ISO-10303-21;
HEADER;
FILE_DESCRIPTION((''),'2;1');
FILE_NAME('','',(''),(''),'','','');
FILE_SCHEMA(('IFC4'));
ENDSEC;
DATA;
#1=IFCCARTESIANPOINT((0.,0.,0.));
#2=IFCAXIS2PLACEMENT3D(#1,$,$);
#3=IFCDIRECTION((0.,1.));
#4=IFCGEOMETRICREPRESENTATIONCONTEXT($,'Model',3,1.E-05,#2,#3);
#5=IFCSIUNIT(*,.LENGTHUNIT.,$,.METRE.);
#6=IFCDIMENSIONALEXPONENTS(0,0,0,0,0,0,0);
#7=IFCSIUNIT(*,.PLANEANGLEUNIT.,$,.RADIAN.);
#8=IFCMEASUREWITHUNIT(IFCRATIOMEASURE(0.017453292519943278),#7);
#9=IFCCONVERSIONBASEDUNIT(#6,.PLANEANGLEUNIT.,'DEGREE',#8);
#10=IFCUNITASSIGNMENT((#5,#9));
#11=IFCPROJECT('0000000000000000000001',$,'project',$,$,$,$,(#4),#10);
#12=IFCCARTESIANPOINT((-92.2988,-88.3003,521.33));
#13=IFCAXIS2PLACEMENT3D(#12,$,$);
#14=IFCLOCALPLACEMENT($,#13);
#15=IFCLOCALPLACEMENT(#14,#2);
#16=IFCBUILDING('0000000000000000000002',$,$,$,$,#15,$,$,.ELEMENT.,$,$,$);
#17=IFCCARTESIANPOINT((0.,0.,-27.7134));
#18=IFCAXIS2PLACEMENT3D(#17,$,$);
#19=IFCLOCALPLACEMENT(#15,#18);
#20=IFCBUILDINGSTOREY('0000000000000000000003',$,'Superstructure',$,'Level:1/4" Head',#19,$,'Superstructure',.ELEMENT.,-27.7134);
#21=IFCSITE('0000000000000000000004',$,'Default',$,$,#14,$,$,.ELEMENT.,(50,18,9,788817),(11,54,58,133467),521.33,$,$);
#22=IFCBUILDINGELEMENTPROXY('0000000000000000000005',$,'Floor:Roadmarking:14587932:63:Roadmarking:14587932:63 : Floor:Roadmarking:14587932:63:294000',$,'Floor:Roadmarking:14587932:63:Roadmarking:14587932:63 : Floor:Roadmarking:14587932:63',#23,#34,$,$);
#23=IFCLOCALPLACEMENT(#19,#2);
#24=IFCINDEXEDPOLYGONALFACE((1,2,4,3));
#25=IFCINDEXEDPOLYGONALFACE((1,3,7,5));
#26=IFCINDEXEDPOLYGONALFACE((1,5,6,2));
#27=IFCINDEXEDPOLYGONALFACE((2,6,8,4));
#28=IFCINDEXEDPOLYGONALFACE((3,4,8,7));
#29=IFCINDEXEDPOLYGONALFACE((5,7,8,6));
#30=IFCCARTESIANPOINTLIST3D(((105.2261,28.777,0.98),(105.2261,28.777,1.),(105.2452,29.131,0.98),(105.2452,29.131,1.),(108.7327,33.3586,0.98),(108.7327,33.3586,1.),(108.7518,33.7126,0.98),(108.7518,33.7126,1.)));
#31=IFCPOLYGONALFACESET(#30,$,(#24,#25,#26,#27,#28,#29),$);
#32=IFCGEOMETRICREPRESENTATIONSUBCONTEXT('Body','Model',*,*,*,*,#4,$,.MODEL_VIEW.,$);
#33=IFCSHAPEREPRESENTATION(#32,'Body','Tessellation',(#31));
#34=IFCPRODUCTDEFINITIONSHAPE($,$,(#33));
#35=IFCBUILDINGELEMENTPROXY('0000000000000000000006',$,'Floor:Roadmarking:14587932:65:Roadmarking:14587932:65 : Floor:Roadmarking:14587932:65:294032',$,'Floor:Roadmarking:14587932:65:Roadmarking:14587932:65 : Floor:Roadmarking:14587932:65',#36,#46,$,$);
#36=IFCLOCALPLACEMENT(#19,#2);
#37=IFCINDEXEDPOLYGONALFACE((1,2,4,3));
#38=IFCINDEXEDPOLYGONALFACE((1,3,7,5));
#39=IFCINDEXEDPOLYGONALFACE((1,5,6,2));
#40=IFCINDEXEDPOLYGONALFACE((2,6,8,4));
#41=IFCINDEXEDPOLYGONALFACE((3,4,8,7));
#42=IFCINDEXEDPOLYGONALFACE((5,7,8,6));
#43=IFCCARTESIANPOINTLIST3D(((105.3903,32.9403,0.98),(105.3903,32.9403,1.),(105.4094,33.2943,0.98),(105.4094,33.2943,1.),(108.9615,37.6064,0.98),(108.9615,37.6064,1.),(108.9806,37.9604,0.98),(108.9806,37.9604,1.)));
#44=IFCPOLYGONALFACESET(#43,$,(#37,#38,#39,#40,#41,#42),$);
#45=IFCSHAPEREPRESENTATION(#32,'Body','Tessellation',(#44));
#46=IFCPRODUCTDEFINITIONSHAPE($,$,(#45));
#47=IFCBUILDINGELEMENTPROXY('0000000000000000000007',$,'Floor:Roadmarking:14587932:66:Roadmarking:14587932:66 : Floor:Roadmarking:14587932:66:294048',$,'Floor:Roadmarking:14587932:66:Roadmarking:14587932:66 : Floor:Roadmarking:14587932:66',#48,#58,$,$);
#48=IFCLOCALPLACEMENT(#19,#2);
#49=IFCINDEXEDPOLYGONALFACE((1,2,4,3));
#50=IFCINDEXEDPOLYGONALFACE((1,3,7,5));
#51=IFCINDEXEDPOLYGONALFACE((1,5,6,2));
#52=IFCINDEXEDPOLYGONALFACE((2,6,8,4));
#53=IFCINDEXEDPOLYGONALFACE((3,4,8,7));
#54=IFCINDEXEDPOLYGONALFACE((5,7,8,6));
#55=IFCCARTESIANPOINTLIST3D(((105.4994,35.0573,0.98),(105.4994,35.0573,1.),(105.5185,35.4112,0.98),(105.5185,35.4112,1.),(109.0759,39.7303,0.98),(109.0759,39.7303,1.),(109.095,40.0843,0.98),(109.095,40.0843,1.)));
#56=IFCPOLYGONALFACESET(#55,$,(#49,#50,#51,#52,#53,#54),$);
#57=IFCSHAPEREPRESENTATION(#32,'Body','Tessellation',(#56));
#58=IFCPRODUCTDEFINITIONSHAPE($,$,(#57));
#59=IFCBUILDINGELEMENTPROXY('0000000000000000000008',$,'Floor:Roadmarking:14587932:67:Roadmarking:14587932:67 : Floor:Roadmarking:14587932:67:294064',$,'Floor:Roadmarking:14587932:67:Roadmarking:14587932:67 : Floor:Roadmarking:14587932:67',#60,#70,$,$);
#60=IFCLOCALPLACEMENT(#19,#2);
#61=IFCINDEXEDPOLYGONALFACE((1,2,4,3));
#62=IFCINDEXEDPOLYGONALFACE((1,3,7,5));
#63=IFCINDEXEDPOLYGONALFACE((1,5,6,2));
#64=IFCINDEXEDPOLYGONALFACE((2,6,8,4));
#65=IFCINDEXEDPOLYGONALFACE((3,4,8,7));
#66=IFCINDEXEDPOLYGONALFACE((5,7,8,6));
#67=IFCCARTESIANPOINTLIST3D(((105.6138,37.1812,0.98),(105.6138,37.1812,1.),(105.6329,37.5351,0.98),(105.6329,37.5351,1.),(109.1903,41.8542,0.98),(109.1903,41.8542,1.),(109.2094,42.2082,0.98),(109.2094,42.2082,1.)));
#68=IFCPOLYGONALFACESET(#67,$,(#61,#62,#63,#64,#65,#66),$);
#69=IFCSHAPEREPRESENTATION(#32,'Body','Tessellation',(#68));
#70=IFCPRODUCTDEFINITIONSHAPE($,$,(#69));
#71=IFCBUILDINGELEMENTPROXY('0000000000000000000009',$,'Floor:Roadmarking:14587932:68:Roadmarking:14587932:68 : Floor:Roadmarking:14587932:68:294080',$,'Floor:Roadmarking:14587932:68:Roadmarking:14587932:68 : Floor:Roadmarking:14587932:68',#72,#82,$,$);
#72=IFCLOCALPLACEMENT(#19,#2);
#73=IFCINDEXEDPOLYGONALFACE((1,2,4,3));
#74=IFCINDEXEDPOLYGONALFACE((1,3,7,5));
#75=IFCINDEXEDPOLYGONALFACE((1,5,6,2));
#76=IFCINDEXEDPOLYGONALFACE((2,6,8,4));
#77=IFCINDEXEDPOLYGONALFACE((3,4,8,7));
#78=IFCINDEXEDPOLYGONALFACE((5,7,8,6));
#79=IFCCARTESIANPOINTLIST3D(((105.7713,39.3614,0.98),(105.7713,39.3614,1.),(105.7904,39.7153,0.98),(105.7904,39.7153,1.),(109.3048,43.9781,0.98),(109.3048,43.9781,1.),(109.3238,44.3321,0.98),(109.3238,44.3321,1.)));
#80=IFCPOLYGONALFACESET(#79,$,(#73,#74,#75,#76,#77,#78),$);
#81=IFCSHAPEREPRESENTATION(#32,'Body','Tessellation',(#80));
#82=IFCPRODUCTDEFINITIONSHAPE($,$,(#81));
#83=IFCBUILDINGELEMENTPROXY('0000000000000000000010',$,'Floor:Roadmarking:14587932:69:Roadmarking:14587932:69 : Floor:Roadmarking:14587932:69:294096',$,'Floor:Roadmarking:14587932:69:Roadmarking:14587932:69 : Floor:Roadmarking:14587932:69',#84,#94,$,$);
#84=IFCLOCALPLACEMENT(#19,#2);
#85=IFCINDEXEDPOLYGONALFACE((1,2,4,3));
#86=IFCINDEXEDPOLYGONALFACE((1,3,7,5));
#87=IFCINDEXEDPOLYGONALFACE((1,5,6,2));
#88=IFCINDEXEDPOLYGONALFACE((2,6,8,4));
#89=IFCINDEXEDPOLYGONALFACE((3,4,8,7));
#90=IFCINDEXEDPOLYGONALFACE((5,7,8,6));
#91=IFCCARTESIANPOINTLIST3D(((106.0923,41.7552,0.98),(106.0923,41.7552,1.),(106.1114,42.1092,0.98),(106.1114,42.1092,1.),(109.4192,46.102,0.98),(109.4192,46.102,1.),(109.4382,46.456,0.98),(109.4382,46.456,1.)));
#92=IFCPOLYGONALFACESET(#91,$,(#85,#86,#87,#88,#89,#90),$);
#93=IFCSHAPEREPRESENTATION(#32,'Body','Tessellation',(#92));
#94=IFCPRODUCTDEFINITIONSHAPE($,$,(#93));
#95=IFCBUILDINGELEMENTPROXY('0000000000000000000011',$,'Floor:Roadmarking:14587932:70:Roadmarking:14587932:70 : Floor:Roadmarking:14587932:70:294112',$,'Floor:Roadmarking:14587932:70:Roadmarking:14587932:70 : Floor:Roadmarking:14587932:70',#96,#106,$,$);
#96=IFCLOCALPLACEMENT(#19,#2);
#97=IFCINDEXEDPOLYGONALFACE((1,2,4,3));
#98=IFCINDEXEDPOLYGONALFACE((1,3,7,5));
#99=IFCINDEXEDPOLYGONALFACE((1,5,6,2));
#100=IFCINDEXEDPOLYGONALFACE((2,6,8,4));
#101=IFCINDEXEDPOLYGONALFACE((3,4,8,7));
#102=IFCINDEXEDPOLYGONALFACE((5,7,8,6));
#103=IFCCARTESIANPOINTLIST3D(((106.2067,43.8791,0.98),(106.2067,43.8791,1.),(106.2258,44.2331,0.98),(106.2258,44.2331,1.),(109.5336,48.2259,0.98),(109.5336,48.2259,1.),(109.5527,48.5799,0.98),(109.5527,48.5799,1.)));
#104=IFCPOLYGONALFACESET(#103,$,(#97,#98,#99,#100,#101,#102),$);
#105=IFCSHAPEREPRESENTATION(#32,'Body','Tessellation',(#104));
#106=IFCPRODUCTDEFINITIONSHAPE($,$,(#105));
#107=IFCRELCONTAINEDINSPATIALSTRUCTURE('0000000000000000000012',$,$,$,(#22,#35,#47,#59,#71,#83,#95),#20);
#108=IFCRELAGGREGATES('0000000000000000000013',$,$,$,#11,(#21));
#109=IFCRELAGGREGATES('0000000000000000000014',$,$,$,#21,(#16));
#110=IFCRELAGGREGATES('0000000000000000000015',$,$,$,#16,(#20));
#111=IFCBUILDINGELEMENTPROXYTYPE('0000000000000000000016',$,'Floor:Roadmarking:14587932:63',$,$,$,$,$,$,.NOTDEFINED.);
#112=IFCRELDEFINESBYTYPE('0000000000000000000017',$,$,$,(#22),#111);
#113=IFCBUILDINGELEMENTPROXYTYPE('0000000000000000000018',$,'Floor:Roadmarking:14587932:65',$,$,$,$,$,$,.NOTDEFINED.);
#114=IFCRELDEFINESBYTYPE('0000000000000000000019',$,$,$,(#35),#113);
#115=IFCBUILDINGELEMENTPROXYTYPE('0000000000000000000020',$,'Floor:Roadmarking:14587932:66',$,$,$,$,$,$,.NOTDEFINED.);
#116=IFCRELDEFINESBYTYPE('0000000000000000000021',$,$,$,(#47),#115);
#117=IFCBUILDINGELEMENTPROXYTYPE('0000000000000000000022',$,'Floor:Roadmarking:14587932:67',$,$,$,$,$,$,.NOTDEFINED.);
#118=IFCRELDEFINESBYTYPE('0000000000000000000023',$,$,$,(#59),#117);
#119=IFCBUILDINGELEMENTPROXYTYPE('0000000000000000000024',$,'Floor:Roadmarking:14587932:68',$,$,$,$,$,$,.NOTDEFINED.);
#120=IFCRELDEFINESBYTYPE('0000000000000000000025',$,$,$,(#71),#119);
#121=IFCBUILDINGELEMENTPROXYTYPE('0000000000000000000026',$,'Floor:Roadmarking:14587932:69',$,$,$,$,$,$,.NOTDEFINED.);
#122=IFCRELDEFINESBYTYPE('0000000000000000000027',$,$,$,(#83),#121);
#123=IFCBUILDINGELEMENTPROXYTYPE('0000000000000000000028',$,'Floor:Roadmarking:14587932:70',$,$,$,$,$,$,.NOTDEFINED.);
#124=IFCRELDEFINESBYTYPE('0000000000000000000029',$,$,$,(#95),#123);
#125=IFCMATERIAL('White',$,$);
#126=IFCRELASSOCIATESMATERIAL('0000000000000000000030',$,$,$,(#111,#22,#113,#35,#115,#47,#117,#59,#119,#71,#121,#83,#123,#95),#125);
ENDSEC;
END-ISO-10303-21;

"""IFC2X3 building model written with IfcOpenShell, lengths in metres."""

from ifc_helpers import new_model, entity, si_unit, converted_unit, direction, frame, origin, place, context, subcontext, project, spatial, polyline, outline, extrude, source, transform, mapped, material, type_object, type_shapes, element, save


model = new_model("IFC2X3")

# Units and contexts
model_context = context("Model", 3, precision=1e-05, world=origin(), true_north=direction((0.0, 1.0)))
body_context = subcontext(model_context, "Body", "Model", "MODEL_VIEW")
ifc_project = project(units=[si_unit("LENGTHUNIT", "METRE"), converted_unit("PLANEANGLEUNIT", "DEGREE", entity("IfcRatioMeasure", 0.017453292519943278), si_unit("PLANEANGLEUNIT", "RADIAN"), dimensions=[0, 0, 0, 0, 0, 0, 0])], contexts=[model_context])

# Site, building, storey
site_placement = place(None, frame((-92.2988, -88.3003, 521.33)))
site = spatial("IfcSite", under=ifc_project, at=site_placement, Name="Default", CompositionType="ELEMENT", RefLatitude=(50, 18, 9, 788817), RefLongitude=(11, 54, 58, 133467), RefElevation=521.33)
building_placement = place(site_placement, origin())
building = spatial("IfcBuilding", under=site, at=building_placement, CompositionType="ELEMENT")
storey_placement = place(building_placement, frame((0.0, 0.0, -27.7134)))
storey = spatial("IfcBuildingStorey", under=building, at=storey_placement, Name="Superstructure", ObjectType="Level:1/4\" Head", LongName="Superstructure", CompositionType="ELEMENT", Elevation=-27.7134)

# Building element proxies
ifc_material = material(Name="White")
building_element_proxy_type_1 = type_object("IfcBuildingElementProxyType", Name="Floor:Roadmarking:14587932:63", PredefinedType="NOTDEFINED", material=ifc_material)
shared_shape_1 = source(origin(), body_context, "Body", "SweptSolid", [
    extrude(outline(polyline([(-3.0311, -0.1), (2.7384, -0.1), (3.0311, 0.1), (-2.7384, 0.1), (-3.0311, -0.1)])), frame((106.9889, 31.2448, -26.7334), z_axis=(0.0, 0.0, 1.0), x_axis=(0.607777, 0.794108, 0.0)), (0.0, 0.0, 1.0), 0.02),
])
type_shapes(building_element_proxy_type_1, [shared_shape_1])
proxy_1_placement = place(storey_placement, frame((0.0, 0.0, 27.7134)))
element("IfcBuildingElementProxy", 1, at=proxy_1_placement, inside=storey, type_object=building_element_proxy_type_1, material=ifc_material, Name="Floor:Roadmarking:14587932:63:Roadmarking:14587932:63 : Floor:Roadmarking:14587932:63:294000", ObjectType="Floor:Roadmarking:14587932:63:Roadmarking:14587932:63 : Floor:Roadmarking:14587932:63", context=body_context, shape_type="MappedRepresentation", body=[
    mapped(shared_shape_1, transform((0.0, 0.0, 0.0), scale=1.0)),
])
building_element_proxy_type_2 = type_object("IfcBuildingElementProxyType", Name="Floor:Roadmarking:14587932:65", PredefinedType="NOTDEFINED", material=ifc_material)
shared_shape_2 = source(origin(), body_context, "Body", "SweptSolid", [
    extrude(outline(polyline([(-3.0843, -0.1), (2.7916, -0.1), (3.0843, 0.1), (-2.7916, 0.1), (-3.0843, -0.1)])), frame((107.1855, 35.4504, -26.7334), z_axis=(0.0, 0.0, 1.0), x_axis=(0.607777, 0.794108, 0.0)), (0.0, 0.0, 1.0), 0.02),
])
type_shapes(building_element_proxy_type_2, [shared_shape_2])
proxy_2_placement = place(storey_placement, frame((0.0, 0.0, 27.7134)))
element("IfcBuildingElementProxy", 2, at=proxy_2_placement, inside=storey, type_object=building_element_proxy_type_2, material=ifc_material, Name="Floor:Roadmarking:14587932:65:Roadmarking:14587932:65 : Floor:Roadmarking:14587932:65:294032", ObjectType="Floor:Roadmarking:14587932:65:Roadmarking:14587932:65 : Floor:Roadmarking:14587932:65", context=body_context, shape_type="MappedRepresentation", body=[
    mapped(shared_shape_2, transform((0.0, 0.0, 0.0), scale=1.0)),
])
building_element_proxy_type_3 = type_object("IfcBuildingElementProxyType", Name="Floor:Roadmarking:14587932:66", PredefinedType="NOTDEFINED", material=ifc_material)
shared_shape_3 = source(origin(), body_context, "Body", "SweptSolid", [
    extrude(outline(polyline([(-3.0887, -0.1), (2.796, -0.1), (3.0887, 0.1), (-2.796, 0.1), (-3.0887, -0.1)])), frame((107.2972, 37.5708, -26.7334), z_axis=(0.0, 0.0, 1.0), x_axis=(0.607777, 0.794108, 0.0)), (0.0, 0.0, 1.0), 0.02),
])
type_shapes(building_element_proxy_type_3, [shared_shape_3])
proxy_3_placement = place(storey_placement, frame((0.0, 0.0, 27.7134)))
element("IfcBuildingElementProxy", 3, at=proxy_3_placement, inside=storey, type_object=building_element_proxy_type_3, material=ifc_material, Name="Floor:Roadmarking:14587932:66:Roadmarking:14587932:66 : Floor:Roadmarking:14587932:66:294048", ObjectType="Floor:Roadmarking:14587932:66:Roadmarking:14587932:66 : Floor:Roadmarking:14587932:66", context=body_context, shape_type="MappedRepresentation", body=[
    mapped(shared_shape_3, transform((0.0, 0.0, 0.0), scale=1.0)),
])
building_element_proxy_type_4 = type_object("IfcBuildingElementProxyType", Name="Floor:Roadmarking:14587932:67", PredefinedType="NOTDEFINED", material=ifc_material)
shared_shape_4 = source(origin(), body_context, "Body", "SweptSolid", [
    extrude(outline(polyline([(-3.0887, -0.1), (2.796, -0.1), (3.0887, 0.1), (-2.796, 0.1), (-3.0887, -0.1)])), frame((107.4116, 39.6947, -26.7334), z_axis=(0.0, 0.0, 1.0), x_axis=(0.607777, 0.794108, 0.0)), (0.0, 0.0, 1.0), 0.02),
])
type_shapes(building_element_proxy_type_4, [shared_shape_4])
proxy_4_placement = place(storey_placement, frame((0.0, 0.0, 27.7134)))
element("IfcBuildingElementProxy", 4, at=proxy_4_placement, inside=storey, type_object=building_element_proxy_type_4, material=ifc_material, Name="Floor:Roadmarking:14587932:67:Roadmarking:14587932:67 : Floor:Roadmarking:14587932:67:294064", ObjectType="Floor:Roadmarking:14587932:67:Roadmarking:14587932:67 : Floor:Roadmarking:14587932:67", context=body_context, shape_type="MappedRepresentation", body=[
    mapped(shared_shape_4, transform((0.0, 0.0, 0.0), scale=1.0)),
])
building_element_proxy_type_5 = type_object("IfcBuildingElementProxyType", Name="Floor:Roadmarking:14587932:68", PredefinedType="NOTDEFINED", material=ifc_material)
shared_shape_5 = source(origin(), body_context, "Body", "SweptSolid", [
    extrude(outline(polyline([(-3.0532, -0.1), (2.7605, -0.1), (3.0532, 0.1), (-2.7605, 0.1), (-3.0532, -0.1)])), frame((107.5476, 41.8467, -26.7334), z_axis=(0.0, 0.0, 1.0), x_axis=(0.607777, 0.794108, 0.0)), (0.0, 0.0, 1.0), 0.02),
])
type_shapes(building_element_proxy_type_5, [shared_shape_5])
proxy_5_placement = place(storey_placement, frame((0.0, 0.0, 27.7134)))
element("IfcBuildingElementProxy", 5, at=proxy_5_placement, inside=storey, type_object=building_element_proxy_type_5, material=ifc_material, Name="Floor:Roadmarking:14587932:68:Roadmarking:14587932:68 : Floor:Roadmarking:14587932:68:294080", ObjectType="Floor:Roadmarking:14587932:68:Roadmarking:14587932:68 : Floor:Roadmarking:14587932:68", context=body_context, shape_type="MappedRepresentation", body=[
    mapped(shared_shape_5, transform((0.0, 0.0, 0.0), scale=1.0)),
])
building_element_proxy_type_6 = type_object("IfcBuildingElementProxyType", Name="Floor:Roadmarking:14587932:69", PredefinedType="NOTDEFINED", material=ifc_material)
shared_shape_6 = source(origin(), body_context, "Body", "SweptSolid", [
    extrude(outline(polyline([(-2.8833, -0.1), (2.5906, -0.1), (2.8833, 0.1), (-2.5906, 0.1), (-2.8833, -0.1)])), frame((107.7653, 44.1056, -26.7334), z_axis=(0.0, 0.0, 1.0), x_axis=(0.607777, 0.794108, 0.0)), (0.0, 0.0, 1.0), 0.02),
])
type_shapes(building_element_proxy_type_6, [shared_shape_6])
proxy_6_placement = place(storey_placement, frame((0.0, 0.0, 27.7134)))
element("IfcBuildingElementProxy", 6, at=proxy_6_placement, inside=storey, type_object=building_element_proxy_type_6, material=ifc_material, Name="Floor:Roadmarking:14587932:69:Roadmarking:14587932:69 : Floor:Roadmarking:14587932:69:294096", ObjectType="Floor:Roadmarking:14587932:69:Roadmarking:14587932:69 : Floor:Roadmarking:14587932:69", context=body_context, shape_type="MappedRepresentation", body=[
    mapped(shared_shape_6, transform((0.0, 0.0, 0.0), scale=1.0)),
])
building_element_proxy_type_7 = type_object("IfcBuildingElementProxyType", Name="Floor:Roadmarking:14587932:70", PredefinedType="NOTDEFINED", material=ifc_material)
shared_shape_7 = source(origin(), body_context, "Body", "SweptSolid", [
    extrude(outline(polyline([(-2.8833, -0.1), (2.5906, -0.1), (2.8833, 0.1), (-2.5906, 0.1), (-2.8833, -0.1)])), frame((107.8797, 46.2295, -26.7334), z_axis=(0.0, 0.0, 1.0), x_axis=(0.607777, 0.794108, 0.0)), (0.0, 0.0, 1.0), 0.02),
])
type_shapes(building_element_proxy_type_7, [shared_shape_7])
proxy_7_placement = place(storey_placement, frame((0.0, 0.0, 27.7134)))
element("IfcBuildingElementProxy", 7, at=proxy_7_placement, inside=storey, type_object=building_element_proxy_type_7, material=ifc_material, Name="Floor:Roadmarking:14587932:70:Roadmarking:14587932:70 : Floor:Roadmarking:14587932:70:294112", ObjectType="Floor:Roadmarking:14587932:70:Roadmarking:14587932:70 : Floor:Roadmarking:14587932:70", context=body_context, shape_type="MappedRepresentation", body=[
    mapped(shared_shape_7, transform((0.0, 0.0, 0.0), scale=1.0)),
])

save(model, "model.ifc")
